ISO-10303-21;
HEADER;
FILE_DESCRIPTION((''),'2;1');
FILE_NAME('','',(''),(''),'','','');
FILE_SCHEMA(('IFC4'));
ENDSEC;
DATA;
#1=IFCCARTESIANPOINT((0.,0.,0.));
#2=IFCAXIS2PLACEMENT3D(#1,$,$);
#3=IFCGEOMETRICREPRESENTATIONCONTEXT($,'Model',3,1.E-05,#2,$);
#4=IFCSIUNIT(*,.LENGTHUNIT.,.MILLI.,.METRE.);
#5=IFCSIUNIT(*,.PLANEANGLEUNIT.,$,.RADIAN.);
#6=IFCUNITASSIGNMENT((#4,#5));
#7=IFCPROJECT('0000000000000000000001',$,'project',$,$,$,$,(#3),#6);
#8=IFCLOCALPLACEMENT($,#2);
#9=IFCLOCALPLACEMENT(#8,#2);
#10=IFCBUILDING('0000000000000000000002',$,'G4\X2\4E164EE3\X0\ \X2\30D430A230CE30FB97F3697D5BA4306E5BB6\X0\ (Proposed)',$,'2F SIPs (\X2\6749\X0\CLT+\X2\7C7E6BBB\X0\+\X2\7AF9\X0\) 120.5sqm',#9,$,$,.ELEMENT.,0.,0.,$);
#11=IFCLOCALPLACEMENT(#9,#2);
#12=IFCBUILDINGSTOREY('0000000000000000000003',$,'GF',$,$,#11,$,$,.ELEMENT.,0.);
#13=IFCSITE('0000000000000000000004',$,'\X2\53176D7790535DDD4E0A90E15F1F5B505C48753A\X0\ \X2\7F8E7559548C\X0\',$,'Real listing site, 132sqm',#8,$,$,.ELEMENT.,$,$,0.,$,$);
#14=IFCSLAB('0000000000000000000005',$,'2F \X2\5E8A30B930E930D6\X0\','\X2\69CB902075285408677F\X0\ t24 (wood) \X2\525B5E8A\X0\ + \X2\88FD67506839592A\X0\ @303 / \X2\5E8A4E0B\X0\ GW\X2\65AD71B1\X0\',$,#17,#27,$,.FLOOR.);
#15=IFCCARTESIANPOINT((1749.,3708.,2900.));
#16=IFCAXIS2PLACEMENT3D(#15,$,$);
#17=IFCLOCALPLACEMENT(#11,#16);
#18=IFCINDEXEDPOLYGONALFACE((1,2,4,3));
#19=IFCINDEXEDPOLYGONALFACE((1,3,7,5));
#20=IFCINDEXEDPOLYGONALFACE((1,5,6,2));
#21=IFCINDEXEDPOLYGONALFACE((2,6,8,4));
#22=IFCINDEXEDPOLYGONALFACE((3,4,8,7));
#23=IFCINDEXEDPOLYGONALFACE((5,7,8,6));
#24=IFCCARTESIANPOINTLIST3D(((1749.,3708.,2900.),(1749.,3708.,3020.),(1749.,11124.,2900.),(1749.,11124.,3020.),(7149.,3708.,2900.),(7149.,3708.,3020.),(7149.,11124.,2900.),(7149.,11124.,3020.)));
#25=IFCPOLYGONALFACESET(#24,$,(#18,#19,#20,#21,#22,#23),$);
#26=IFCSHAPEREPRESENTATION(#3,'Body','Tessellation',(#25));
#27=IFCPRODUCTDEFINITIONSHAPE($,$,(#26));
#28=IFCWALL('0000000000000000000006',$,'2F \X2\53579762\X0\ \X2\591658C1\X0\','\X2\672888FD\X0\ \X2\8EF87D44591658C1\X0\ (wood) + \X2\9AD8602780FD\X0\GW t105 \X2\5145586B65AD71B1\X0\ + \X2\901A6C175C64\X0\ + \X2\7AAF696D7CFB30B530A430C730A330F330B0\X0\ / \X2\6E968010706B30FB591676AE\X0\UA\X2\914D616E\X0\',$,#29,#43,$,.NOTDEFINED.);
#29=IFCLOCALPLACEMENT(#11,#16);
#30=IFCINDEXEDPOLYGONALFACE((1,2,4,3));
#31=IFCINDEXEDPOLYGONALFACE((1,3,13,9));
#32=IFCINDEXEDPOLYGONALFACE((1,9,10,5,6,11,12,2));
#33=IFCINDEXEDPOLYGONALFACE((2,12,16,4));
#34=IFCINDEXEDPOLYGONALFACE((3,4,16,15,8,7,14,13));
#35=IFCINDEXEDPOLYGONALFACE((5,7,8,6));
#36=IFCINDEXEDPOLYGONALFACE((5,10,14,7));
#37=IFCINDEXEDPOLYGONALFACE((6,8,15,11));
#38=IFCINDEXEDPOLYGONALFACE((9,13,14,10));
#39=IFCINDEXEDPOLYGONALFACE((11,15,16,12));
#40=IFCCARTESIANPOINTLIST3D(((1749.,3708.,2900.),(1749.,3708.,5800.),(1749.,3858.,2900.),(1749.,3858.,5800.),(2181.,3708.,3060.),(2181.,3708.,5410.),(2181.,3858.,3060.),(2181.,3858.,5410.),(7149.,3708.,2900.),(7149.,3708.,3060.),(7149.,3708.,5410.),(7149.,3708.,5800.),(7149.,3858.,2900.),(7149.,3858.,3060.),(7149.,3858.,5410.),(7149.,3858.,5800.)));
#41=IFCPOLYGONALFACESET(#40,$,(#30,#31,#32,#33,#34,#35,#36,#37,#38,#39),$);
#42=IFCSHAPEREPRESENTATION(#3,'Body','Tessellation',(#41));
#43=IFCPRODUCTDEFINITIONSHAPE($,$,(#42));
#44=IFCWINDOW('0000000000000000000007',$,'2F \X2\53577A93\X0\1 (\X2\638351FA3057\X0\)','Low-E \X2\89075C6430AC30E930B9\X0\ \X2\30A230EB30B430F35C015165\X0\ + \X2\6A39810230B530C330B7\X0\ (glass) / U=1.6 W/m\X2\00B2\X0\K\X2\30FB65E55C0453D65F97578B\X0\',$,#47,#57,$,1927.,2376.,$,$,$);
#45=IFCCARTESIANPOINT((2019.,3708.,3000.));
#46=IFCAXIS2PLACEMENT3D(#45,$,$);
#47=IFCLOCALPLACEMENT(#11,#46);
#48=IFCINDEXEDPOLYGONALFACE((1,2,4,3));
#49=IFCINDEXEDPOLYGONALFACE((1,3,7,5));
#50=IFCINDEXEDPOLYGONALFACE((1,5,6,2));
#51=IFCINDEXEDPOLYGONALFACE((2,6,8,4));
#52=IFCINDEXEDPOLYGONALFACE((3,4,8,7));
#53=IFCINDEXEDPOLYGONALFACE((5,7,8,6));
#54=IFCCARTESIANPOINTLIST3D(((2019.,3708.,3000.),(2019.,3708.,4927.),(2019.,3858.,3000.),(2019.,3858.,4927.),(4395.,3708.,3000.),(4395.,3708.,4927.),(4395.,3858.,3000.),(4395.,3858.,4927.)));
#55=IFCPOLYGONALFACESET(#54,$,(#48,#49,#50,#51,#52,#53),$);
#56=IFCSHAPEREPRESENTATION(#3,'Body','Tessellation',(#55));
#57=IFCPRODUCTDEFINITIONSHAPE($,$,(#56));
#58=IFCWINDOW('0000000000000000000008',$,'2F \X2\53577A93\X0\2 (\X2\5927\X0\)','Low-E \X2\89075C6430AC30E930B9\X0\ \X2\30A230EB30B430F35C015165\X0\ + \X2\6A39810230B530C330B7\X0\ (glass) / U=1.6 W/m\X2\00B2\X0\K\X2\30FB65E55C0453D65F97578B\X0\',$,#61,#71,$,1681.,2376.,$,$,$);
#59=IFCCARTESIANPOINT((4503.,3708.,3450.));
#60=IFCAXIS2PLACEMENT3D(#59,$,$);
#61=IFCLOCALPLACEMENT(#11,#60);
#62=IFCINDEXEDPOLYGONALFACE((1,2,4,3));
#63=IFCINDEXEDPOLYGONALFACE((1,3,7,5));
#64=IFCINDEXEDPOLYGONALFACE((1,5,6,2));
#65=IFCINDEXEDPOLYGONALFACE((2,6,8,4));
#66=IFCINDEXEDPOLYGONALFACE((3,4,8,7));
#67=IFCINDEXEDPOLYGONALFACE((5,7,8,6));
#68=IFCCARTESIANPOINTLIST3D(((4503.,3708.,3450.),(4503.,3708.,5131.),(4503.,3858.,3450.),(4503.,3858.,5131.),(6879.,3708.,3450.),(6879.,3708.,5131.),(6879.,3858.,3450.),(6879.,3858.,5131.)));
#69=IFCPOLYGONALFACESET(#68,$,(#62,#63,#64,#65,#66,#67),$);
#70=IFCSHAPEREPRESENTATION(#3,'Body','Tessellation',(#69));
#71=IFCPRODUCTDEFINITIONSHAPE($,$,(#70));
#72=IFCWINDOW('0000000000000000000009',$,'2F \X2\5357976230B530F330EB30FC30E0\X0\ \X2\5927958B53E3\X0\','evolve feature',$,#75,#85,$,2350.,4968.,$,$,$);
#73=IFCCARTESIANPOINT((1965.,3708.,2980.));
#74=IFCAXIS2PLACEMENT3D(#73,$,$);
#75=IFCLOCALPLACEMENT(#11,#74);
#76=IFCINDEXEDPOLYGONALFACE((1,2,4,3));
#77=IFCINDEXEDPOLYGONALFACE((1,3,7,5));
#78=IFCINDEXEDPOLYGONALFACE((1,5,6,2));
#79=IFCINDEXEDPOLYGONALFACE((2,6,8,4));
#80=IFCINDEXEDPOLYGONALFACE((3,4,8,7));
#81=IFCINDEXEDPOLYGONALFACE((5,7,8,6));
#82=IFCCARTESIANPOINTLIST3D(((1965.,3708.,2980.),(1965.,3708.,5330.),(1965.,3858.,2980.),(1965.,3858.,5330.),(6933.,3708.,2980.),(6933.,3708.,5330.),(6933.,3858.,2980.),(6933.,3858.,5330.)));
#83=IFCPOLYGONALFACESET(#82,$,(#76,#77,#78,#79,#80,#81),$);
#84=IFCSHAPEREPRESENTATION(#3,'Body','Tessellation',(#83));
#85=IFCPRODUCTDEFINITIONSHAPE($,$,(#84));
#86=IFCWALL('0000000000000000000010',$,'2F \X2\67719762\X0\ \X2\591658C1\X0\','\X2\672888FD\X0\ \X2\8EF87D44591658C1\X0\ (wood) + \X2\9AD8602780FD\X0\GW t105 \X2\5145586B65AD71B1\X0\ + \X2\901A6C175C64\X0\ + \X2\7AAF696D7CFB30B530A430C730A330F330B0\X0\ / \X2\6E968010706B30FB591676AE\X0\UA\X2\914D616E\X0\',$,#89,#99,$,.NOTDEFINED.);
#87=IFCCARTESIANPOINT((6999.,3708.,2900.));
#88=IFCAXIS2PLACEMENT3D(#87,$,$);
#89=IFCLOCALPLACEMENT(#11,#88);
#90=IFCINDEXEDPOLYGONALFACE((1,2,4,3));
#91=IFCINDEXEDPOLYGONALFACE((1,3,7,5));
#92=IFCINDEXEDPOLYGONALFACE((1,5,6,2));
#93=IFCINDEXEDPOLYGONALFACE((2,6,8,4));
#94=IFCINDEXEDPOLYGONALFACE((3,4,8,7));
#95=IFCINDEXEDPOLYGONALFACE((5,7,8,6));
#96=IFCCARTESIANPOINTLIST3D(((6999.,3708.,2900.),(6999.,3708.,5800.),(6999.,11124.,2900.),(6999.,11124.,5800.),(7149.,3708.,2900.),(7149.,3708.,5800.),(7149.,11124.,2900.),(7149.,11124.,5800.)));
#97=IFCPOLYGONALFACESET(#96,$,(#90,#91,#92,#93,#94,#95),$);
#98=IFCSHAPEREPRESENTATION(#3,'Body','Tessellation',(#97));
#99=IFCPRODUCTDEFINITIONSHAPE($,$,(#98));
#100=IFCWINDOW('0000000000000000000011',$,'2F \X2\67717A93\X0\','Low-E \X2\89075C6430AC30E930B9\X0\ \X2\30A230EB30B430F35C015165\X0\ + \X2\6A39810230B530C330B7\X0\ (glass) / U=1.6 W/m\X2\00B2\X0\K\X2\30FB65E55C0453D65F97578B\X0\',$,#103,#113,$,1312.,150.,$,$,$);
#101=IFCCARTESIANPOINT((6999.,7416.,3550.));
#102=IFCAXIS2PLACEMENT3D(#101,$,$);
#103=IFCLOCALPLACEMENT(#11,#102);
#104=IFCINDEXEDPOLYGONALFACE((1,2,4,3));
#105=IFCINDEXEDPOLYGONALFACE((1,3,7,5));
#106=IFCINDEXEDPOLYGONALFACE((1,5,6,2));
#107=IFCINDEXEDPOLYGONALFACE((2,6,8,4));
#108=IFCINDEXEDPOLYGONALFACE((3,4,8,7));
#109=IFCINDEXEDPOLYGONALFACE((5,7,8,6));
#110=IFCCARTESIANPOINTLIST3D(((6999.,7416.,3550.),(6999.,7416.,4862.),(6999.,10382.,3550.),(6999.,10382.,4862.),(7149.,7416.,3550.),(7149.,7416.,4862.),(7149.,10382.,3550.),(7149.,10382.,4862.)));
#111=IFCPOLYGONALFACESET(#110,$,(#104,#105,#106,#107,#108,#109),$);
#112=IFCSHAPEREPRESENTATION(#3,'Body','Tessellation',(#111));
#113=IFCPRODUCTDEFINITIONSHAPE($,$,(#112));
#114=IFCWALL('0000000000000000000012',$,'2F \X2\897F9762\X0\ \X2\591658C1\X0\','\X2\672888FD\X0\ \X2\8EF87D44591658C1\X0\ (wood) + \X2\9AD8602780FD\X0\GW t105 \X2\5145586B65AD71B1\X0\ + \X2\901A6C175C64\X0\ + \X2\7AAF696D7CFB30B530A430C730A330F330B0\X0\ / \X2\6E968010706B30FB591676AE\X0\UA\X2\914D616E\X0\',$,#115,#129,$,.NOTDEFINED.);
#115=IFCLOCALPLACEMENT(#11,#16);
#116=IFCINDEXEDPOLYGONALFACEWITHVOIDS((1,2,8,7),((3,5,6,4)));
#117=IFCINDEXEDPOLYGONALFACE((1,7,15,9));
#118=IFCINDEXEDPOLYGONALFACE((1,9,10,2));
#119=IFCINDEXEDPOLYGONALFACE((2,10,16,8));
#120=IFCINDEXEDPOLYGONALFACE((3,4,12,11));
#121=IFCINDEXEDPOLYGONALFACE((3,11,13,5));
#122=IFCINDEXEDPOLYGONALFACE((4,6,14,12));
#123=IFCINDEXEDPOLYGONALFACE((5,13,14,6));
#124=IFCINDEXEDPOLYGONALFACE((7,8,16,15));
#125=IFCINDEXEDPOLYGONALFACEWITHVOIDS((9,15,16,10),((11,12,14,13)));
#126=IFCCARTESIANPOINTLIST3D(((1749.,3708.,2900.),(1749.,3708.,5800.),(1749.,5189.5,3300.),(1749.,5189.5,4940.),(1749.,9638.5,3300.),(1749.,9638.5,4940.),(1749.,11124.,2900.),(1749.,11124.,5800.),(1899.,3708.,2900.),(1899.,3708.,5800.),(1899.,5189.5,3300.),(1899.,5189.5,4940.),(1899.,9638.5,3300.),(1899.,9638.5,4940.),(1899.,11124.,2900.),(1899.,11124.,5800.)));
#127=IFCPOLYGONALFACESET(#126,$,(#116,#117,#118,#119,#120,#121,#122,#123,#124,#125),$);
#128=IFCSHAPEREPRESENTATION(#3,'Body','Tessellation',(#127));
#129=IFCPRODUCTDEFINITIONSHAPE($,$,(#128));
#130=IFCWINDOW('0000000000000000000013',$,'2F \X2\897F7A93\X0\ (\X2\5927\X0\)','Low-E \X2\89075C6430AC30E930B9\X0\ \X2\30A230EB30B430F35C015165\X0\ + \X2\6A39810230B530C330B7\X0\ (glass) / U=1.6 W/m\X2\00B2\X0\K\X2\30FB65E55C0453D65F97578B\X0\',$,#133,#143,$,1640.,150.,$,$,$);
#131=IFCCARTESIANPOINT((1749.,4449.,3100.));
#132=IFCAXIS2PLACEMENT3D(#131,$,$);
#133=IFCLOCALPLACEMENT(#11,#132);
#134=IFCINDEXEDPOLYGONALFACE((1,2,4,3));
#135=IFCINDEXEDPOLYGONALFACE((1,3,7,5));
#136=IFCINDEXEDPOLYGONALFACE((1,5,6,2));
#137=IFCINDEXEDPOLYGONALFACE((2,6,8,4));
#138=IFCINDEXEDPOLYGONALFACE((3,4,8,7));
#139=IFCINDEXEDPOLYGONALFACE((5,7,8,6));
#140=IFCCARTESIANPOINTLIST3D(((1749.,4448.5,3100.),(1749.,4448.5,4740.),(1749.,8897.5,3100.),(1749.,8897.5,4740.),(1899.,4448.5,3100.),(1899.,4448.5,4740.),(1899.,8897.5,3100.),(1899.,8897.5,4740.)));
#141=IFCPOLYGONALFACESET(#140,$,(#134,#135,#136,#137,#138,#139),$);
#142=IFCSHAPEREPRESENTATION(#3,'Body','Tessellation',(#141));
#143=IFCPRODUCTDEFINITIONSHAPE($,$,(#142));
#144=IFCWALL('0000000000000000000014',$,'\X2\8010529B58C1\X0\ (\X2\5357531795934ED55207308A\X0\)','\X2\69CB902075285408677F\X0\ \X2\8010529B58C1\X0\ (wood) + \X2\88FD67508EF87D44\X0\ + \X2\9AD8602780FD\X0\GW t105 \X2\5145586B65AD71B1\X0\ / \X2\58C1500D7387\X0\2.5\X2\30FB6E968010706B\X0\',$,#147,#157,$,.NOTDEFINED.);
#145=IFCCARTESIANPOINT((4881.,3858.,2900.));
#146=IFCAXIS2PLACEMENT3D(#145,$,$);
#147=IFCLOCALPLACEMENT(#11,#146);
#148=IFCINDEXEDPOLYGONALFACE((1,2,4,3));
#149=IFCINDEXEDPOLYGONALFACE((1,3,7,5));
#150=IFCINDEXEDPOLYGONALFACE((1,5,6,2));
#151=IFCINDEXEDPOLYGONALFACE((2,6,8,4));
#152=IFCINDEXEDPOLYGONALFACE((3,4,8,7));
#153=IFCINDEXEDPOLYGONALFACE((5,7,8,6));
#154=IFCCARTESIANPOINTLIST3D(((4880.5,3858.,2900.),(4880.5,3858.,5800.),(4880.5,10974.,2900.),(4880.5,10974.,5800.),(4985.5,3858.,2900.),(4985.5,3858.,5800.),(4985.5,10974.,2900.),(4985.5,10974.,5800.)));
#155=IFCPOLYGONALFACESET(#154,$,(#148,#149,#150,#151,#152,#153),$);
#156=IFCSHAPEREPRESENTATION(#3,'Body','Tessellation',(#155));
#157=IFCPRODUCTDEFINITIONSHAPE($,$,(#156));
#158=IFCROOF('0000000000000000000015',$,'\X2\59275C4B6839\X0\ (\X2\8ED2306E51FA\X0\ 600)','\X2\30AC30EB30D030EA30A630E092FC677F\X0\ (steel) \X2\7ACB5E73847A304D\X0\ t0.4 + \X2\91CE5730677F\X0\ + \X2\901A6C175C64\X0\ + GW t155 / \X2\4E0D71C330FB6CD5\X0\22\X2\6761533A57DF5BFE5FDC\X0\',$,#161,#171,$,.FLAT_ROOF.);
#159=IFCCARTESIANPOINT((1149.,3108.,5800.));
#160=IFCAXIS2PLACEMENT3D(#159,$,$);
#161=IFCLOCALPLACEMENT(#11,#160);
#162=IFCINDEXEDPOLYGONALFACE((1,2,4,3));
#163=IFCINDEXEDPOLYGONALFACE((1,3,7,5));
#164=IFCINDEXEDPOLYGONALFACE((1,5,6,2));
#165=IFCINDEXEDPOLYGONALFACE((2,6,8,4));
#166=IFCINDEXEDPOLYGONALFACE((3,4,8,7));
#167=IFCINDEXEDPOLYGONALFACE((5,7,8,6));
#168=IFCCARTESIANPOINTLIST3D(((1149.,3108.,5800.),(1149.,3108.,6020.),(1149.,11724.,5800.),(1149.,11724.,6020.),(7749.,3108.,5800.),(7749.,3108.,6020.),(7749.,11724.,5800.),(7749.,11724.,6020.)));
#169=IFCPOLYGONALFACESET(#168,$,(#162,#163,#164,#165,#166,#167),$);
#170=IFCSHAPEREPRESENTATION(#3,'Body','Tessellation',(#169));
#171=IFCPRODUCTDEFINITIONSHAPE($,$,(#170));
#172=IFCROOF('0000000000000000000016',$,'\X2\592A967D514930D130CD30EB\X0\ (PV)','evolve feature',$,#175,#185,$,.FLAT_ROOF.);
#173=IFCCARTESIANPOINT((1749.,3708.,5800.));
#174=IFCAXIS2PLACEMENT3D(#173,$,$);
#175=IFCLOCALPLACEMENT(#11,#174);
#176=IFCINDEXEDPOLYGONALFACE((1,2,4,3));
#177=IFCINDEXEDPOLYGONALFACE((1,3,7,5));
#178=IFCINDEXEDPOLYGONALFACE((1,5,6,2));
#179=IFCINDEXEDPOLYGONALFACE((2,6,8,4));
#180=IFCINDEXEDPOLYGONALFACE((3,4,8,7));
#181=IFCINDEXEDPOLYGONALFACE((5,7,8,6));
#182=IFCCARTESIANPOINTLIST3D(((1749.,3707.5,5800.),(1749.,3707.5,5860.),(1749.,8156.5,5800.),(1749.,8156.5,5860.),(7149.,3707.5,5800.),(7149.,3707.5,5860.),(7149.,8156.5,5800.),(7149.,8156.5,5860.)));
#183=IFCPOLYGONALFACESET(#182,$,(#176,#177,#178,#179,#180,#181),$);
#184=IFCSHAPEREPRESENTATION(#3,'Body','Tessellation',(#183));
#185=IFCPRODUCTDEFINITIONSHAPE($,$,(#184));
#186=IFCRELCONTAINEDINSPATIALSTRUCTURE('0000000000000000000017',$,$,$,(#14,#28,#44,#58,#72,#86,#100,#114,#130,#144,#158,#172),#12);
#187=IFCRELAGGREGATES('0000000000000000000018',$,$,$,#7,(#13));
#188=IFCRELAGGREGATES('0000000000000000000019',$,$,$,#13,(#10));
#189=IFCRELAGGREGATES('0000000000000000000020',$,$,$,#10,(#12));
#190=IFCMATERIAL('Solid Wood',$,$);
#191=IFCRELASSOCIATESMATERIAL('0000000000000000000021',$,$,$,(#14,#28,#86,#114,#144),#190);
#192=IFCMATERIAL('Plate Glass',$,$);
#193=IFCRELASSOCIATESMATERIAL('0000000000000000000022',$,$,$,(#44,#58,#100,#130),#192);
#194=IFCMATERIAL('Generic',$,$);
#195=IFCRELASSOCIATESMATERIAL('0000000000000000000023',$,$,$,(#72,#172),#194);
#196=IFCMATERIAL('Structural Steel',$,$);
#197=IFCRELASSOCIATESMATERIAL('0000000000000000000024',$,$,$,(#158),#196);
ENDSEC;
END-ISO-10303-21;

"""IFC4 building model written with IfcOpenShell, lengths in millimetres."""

from ifc_helpers import new_model, si_unit, frame, frame_2d, origin, place, context, project, spatial, rectangle, extrude, material, element, fill, save


model = new_model("IFC4")

# Units and contexts
model_context = context("Model", 3, precision=1e-05, world=origin())
ifc_project = project(units=[si_unit("LENGTHUNIT", "METRE", prefix="MILLI"), si_unit("PLANEANGLEUNIT", "RADIAN")], contexts=[model_context])

# Site, building, storey
site_placement = place(None, origin())
site = spatial("IfcSite", under=ifc_project, at=site_placement, Name="北海道川上郡弟子屈町 美留和", ObjectType="Real listing site, 132sqm", CompositionType="ELEMENT", RefElevation=0.0)
building_placement = place(site_placement, origin())
building = spatial("IfcBuilding", under=site, at=building_placement, Name="G4世代 ピアノ・音楽室の家 (Proposed)", ObjectType="2F SIPs (杉CLT+籾殻+竹) 120.5sqm", CompositionType="ELEMENT", ElevationOfRefHeight=0.0, ElevationOfTerrain=0.0)
storey_placement = place(building_placement, origin())
storey = spatial("IfcBuildingStorey", under=building, at=storey_placement, Name="GF", CompositionType="ELEMENT", Elevation=0.0)

# Slab
ifc_material_1 = material(Name="Solid Wood")
slab_placement = place(storey_placement, frame((1749.0, 3708.0, 2900.0)))
element("IfcSlab", 1, at=slab_placement, inside=storey, material=ifc_material_1, Name="2F 床スラブ", Description="構造用合板 t24 (wood) 剛床 + 製材根太 @303 / 床下 GW断熱", PredefinedType="FLOOR", context=model_context, shape_type="SweptSolid", body=[
    extrude(rectangle(XDim=5400.0, YDim=7416.0, at=frame_2d((2700.0, 3708.0))), frame((1749.0, 3708.0, 2900.0)), (0.0, 0.0, 1.0), 120.0),
])

# Wall, openings, windows
wall_1_placement = place(storey_placement, frame((1749.0, 3708.0, 2900.0)))
wall_1 = element("IfcWall", 2, at=wall_1_placement, inside=storey, material=ifc_material_1, Name="2F 南面 外壁", Description="木製 軸組外壁 (wood) + 高性能GW t105 充填断熱 + 通気層 + 窯業系サイディング / 準耐火・外皮UA配慮", PredefinedType="NOTDEFINED", context=model_context, shape_type="SweptSolid", body=[
    extrude(rectangle(XDim=5400.0, YDim=150.0, at=frame_2d((2700.0, 75.0))), frame((1749.0, 3708.0, 2900.0)), (0.0, 0.0, 1.0), 2900.0),
])
opening_1_placement = place(storey_placement, frame((2019.0, 3708.0, 3000.0)))
opening_1 = element("IfcOpeningElement", 3, at=opening_1_placement, cuts=wall_1, PredefinedType="NOTDEFINED", context=model_context, shape_type="SweptSolid", body=[
    extrude(rectangle(XDim=2376.0, YDim=150.0, at=frame_2d((1188.0, 75.0))), frame((2019.0, 3708.0, 3000.0)), (0.0, 0.0, 1.0), 1927.0),
])
opening_2_placement = place(storey_placement, frame((4503.0, 3708.0, 3450.0)))
opening_2 = element("IfcOpeningElement", 4, at=opening_2_placement, cuts=wall_1, PredefinedType="NOTDEFINED", context=model_context, shape_type="SweptSolid", body=[
    extrude(rectangle(XDim=2376.0, YDim=150.0, at=frame_2d((1188.0, 75.0))), frame((4503.0, 3708.0, 3450.0)), (0.0, 0.0, 1.0), 1681.0),
])
opening_3_placement = place(storey_placement, frame((1965.0, 3708.0, 2980.0)))
opening_3 = element("IfcOpeningElement", 5, at=opening_3_placement, cuts=wall_1, PredefinedType="NOTDEFINED", context=model_context, shape_type="SweptSolid", body=[
    extrude(rectangle(XDim=4968.0, YDim=150.0, at=frame_2d((2484.0, 75.0))), frame((1965.0, 3708.0, 2980.0)), (0.0, 0.0, 1.0), 2350.0),
])
ifc_material_2 = material(Name="Plate Glass")
window_1_placement = place(storey_placement, frame((2019.0, 3708.0, 3000.0)))
window_1 = element("IfcWindow", 6, at=window_1_placement, inside=storey, material=ifc_material_2, Name="2F 南窓1 (掃出し)", Description="Low-E 複層ガラス アルゴン封入 + 樹脂サッシ (glass) / U=1.6 W/m²K・日射取得型", OverallHeight=1927.0, OverallWidth=2376.0, context=model_context, shape_type="SweptSolid", body=[
    extrude(rectangle(XDim=2376.0, YDim=150.0, at=frame_2d((1188.0, 75.0))), frame((2019.0, 3708.0, 3000.0)), (0.0, 0.0, 1.0), 1927.0),
])
fill(opening_1, window_1)
window_2_placement = place(storey_placement, frame((4503.0, 3708.0, 3450.0)))
window_2 = element("IfcWindow", 7, at=window_2_placement, inside=storey, material=ifc_material_2, Name="2F 南窓2 (大)", Description="Low-E 複層ガラス アルゴン封入 + 樹脂サッシ (glass) / U=1.6 W/m²K・日射取得型", OverallHeight=1681.0, OverallWidth=2376.0, context=model_context, shape_type="SweptSolid", body=[
    extrude(rectangle(XDim=2376.0, YDim=150.0, at=frame_2d((1188.0, 75.0))), frame((4503.0, 3708.0, 3450.0)), (0.0, 0.0, 1.0), 1681.0),
])
fill(opening_2, window_2)
ifc_material_3 = material(Name="Generic")
window_3_placement = place(storey_placement, frame((1965.0, 3708.0, 2980.0)))
window_3 = element("IfcWindow", 8, at=window_3_placement, inside=storey, material=ifc_material_3, Name="2F 南面サンルーム 大開口", Description="evolve feature", OverallHeight=2350.0, OverallWidth=4968.0, context=model_context, shape_type="SweptSolid", body=[
    extrude(rectangle(XDim=4968.0, YDim=150.0, at=frame_2d((2484.0, 75.0))), frame((1965.0, 3708.0, 2980.0)), (0.0, 0.0, 1.0), 2350.0),
])
fill(opening_3, window_3)

# Walls, openings, windows
wall_2_placement = place(storey_placement, frame((6999.0, 3708.0, 2900.0)))
wall_2 = element("IfcWall", 9, at=wall_2_placement, inside=storey, material=ifc_material_1, Name="2F 東面 外壁", Description="木製 軸組外壁 (wood) + 高性能GW t105 充填断熱 + 通気層 + 窯業系サイディング / 準耐火・外皮UA配慮", PredefinedType="NOTDEFINED", context=model_context, shape_type="SweptSolid", body=[
    extrude(rectangle(XDim=150.0, YDim=7416.0, at=frame_2d((75.0, 3708.0))), frame((6999.0, 3708.0, 2900.0)), (0.0, 0.0, 1.0), 2900.0),
])
opening_4_placement = place(storey_placement, frame((6999.0, 7416.0, 3550.0)))
opening_4 = element("IfcOpeningElement", 10, at=opening_4_placement, cuts=wall_2, PredefinedType="NOTDEFINED", context=model_context, shape_type="SweptSolid", body=[
    extrude(rectangle(XDim=150.0, YDim=2966.0, at=frame_2d((75.0, 1483.0))), frame((6999.0, 7416.0, 3550.0)), (0.0, 0.0, 1.0), 1312.0),
])
window_4_placement = place(storey_placement, frame((6999.0, 7416.0, 3550.0)))
window_4 = element("IfcWindow", 11, at=window_4_placement, inside=storey, material=ifc_material_2, Name="2F 東窓", Description="Low-E 複層ガラス アルゴン封入 + 樹脂サッシ (glass) / U=1.6 W/m²K・日射取得型", OverallHeight=1312.0, OverallWidth=150.0, context=model_context, shape_type="SweptSolid", body=[
    extrude(rectangle(XDim=150.0, YDim=2966.0, at=frame_2d((75.0, 1483.0))), frame((6999.0, 7416.0, 3550.0)), (0.0, 0.0, 1.0), 1312.0),
])
fill(opening_4, window_4)
wall_3_placement = place(storey_placement, frame((1749.0, 3708.0, 2900.0)))
wall_3 = element("IfcWall", 12, at=wall_3_placement, inside=storey, material=ifc_material_1, Name="2F 西面 外壁", Description="木製 軸組外壁 (wood) + 高性能GW t105 充填断熱 + 通気層 + 窯業系サイディング / 準耐火・外皮UA配慮", PredefinedType="NOTDEFINED", context=model_context, shape_type="SweptSolid", body=[
    extrude(rectangle(XDim=150.0, YDim=7416.0, at=frame_2d((75.0, 3708.0))), frame((1749.0, 3708.0, 2900.0)), (0.0, 0.0, 1.0), 2900.0),
])
opening_5_placement = place(storey_placement, frame((1749.0, 4449.0, 3100.0)))
opening_5 = element("IfcOpeningElement", 13, at=opening_5_placement, cuts=wall_3, PredefinedType="NOTDEFINED", context=model_context, shape_type="SweptSolid", body=[
    extrude(rectangle(XDim=150.0, YDim=4449.0, at=frame_2d((75.0, 2224.0))), frame((1749.0, 4449.0, 3100.0)), (0.0, 0.0, 1.0), 1640.0),
])
window_5_placement = place(storey_placement, frame((1749.0, 4449.0, 3100.0)))
window_5 = element("IfcWindow", 14, at=window_5_placement, inside=storey, material=ifc_material_2, Name="2F 西窓 (大)", Description="Low-E 複層ガラス アルゴン封入 + 樹脂サッシ (glass) / U=1.6 W/m²K・日射取得型", OverallHeight=1640.0, OverallWidth=150.0, context=model_context, shape_type="SweptSolid", body=[
    extrude(rectangle(XDim=150.0, YDim=4449.0, at=frame_2d((75.0, 2224.0))), frame((1749.0, 4449.0, 3100.0)), (0.0, 0.0, 1.0), 1640.0),
])
fill(opening_5, window_5)

# Wall
wall_4_placement = place(storey_placement, frame((4881.0, 3858.0, 2900.0)))
element("IfcWall", 15, at=wall_4_placement, inside=storey, material=ifc_material_1, Name="耐力壁 (南北間仕切り)", Description="構造用合板 耐力壁 (wood) + 製材軸組 + 高性能GW t105 充填断熱 / 壁倍率2.5・準耐火", PredefinedType="NOTDEFINED", context=model_context, shape_type="SweptSolid", body=[
    extrude(rectangle(XDim=105.0, YDim=7116.0, at=frame_2d((52.0, 3558.0))), frame((4881.0, 3858.0, 2900.0)), (0.0, 0.0, 1.0), 2900.0),
])

# Roofs
ifc_material_4 = material(Name="Structural Steel")
roof_1_placement = place(storey_placement, frame((1149.0, 3108.0, 5800.0)))
element("IfcRoof", 16, at=roof_1_placement, inside=storey, material=ifc_material_4, Name="大屋根 (軒の出 600)", Description="ガルバリウム鋼板 (steel) 立平葺き t0.4 + 野地板 + 通気層 + GW t155 / 不燃・法22条区域対応", PredefinedType="FLAT_ROOF", context=model_context, shape_type="SweptSolid", body=[
    extrude(rectangle(XDim=6600.0, YDim=8616.0, at=frame_2d((3300.0, 4308.0))), frame((1149.0, 3108.0, 5800.0)), (0.0, 0.0, 1.0), 220.0),
])
roof_2_placement = place(storey_placement, frame((1749.0, 3708.0, 5800.0)))
element("IfcRoof", 17, at=roof_2_placement, inside=storey, material=ifc_material_3, Name="太陽光パネル (PV)", Description="evolve feature", PredefinedType="FLAT_ROOF", context=model_context, shape_type="SweptSolid", body=[
    extrude(rectangle(XDim=5400.0, YDim=4449.0, at=frame_2d((2700.0, 2224.0))), frame((1749.0, 3708.0, 5800.0)), (0.0, 0.0, 1.0), 60.0),
])

save(model, "model.ifc")
